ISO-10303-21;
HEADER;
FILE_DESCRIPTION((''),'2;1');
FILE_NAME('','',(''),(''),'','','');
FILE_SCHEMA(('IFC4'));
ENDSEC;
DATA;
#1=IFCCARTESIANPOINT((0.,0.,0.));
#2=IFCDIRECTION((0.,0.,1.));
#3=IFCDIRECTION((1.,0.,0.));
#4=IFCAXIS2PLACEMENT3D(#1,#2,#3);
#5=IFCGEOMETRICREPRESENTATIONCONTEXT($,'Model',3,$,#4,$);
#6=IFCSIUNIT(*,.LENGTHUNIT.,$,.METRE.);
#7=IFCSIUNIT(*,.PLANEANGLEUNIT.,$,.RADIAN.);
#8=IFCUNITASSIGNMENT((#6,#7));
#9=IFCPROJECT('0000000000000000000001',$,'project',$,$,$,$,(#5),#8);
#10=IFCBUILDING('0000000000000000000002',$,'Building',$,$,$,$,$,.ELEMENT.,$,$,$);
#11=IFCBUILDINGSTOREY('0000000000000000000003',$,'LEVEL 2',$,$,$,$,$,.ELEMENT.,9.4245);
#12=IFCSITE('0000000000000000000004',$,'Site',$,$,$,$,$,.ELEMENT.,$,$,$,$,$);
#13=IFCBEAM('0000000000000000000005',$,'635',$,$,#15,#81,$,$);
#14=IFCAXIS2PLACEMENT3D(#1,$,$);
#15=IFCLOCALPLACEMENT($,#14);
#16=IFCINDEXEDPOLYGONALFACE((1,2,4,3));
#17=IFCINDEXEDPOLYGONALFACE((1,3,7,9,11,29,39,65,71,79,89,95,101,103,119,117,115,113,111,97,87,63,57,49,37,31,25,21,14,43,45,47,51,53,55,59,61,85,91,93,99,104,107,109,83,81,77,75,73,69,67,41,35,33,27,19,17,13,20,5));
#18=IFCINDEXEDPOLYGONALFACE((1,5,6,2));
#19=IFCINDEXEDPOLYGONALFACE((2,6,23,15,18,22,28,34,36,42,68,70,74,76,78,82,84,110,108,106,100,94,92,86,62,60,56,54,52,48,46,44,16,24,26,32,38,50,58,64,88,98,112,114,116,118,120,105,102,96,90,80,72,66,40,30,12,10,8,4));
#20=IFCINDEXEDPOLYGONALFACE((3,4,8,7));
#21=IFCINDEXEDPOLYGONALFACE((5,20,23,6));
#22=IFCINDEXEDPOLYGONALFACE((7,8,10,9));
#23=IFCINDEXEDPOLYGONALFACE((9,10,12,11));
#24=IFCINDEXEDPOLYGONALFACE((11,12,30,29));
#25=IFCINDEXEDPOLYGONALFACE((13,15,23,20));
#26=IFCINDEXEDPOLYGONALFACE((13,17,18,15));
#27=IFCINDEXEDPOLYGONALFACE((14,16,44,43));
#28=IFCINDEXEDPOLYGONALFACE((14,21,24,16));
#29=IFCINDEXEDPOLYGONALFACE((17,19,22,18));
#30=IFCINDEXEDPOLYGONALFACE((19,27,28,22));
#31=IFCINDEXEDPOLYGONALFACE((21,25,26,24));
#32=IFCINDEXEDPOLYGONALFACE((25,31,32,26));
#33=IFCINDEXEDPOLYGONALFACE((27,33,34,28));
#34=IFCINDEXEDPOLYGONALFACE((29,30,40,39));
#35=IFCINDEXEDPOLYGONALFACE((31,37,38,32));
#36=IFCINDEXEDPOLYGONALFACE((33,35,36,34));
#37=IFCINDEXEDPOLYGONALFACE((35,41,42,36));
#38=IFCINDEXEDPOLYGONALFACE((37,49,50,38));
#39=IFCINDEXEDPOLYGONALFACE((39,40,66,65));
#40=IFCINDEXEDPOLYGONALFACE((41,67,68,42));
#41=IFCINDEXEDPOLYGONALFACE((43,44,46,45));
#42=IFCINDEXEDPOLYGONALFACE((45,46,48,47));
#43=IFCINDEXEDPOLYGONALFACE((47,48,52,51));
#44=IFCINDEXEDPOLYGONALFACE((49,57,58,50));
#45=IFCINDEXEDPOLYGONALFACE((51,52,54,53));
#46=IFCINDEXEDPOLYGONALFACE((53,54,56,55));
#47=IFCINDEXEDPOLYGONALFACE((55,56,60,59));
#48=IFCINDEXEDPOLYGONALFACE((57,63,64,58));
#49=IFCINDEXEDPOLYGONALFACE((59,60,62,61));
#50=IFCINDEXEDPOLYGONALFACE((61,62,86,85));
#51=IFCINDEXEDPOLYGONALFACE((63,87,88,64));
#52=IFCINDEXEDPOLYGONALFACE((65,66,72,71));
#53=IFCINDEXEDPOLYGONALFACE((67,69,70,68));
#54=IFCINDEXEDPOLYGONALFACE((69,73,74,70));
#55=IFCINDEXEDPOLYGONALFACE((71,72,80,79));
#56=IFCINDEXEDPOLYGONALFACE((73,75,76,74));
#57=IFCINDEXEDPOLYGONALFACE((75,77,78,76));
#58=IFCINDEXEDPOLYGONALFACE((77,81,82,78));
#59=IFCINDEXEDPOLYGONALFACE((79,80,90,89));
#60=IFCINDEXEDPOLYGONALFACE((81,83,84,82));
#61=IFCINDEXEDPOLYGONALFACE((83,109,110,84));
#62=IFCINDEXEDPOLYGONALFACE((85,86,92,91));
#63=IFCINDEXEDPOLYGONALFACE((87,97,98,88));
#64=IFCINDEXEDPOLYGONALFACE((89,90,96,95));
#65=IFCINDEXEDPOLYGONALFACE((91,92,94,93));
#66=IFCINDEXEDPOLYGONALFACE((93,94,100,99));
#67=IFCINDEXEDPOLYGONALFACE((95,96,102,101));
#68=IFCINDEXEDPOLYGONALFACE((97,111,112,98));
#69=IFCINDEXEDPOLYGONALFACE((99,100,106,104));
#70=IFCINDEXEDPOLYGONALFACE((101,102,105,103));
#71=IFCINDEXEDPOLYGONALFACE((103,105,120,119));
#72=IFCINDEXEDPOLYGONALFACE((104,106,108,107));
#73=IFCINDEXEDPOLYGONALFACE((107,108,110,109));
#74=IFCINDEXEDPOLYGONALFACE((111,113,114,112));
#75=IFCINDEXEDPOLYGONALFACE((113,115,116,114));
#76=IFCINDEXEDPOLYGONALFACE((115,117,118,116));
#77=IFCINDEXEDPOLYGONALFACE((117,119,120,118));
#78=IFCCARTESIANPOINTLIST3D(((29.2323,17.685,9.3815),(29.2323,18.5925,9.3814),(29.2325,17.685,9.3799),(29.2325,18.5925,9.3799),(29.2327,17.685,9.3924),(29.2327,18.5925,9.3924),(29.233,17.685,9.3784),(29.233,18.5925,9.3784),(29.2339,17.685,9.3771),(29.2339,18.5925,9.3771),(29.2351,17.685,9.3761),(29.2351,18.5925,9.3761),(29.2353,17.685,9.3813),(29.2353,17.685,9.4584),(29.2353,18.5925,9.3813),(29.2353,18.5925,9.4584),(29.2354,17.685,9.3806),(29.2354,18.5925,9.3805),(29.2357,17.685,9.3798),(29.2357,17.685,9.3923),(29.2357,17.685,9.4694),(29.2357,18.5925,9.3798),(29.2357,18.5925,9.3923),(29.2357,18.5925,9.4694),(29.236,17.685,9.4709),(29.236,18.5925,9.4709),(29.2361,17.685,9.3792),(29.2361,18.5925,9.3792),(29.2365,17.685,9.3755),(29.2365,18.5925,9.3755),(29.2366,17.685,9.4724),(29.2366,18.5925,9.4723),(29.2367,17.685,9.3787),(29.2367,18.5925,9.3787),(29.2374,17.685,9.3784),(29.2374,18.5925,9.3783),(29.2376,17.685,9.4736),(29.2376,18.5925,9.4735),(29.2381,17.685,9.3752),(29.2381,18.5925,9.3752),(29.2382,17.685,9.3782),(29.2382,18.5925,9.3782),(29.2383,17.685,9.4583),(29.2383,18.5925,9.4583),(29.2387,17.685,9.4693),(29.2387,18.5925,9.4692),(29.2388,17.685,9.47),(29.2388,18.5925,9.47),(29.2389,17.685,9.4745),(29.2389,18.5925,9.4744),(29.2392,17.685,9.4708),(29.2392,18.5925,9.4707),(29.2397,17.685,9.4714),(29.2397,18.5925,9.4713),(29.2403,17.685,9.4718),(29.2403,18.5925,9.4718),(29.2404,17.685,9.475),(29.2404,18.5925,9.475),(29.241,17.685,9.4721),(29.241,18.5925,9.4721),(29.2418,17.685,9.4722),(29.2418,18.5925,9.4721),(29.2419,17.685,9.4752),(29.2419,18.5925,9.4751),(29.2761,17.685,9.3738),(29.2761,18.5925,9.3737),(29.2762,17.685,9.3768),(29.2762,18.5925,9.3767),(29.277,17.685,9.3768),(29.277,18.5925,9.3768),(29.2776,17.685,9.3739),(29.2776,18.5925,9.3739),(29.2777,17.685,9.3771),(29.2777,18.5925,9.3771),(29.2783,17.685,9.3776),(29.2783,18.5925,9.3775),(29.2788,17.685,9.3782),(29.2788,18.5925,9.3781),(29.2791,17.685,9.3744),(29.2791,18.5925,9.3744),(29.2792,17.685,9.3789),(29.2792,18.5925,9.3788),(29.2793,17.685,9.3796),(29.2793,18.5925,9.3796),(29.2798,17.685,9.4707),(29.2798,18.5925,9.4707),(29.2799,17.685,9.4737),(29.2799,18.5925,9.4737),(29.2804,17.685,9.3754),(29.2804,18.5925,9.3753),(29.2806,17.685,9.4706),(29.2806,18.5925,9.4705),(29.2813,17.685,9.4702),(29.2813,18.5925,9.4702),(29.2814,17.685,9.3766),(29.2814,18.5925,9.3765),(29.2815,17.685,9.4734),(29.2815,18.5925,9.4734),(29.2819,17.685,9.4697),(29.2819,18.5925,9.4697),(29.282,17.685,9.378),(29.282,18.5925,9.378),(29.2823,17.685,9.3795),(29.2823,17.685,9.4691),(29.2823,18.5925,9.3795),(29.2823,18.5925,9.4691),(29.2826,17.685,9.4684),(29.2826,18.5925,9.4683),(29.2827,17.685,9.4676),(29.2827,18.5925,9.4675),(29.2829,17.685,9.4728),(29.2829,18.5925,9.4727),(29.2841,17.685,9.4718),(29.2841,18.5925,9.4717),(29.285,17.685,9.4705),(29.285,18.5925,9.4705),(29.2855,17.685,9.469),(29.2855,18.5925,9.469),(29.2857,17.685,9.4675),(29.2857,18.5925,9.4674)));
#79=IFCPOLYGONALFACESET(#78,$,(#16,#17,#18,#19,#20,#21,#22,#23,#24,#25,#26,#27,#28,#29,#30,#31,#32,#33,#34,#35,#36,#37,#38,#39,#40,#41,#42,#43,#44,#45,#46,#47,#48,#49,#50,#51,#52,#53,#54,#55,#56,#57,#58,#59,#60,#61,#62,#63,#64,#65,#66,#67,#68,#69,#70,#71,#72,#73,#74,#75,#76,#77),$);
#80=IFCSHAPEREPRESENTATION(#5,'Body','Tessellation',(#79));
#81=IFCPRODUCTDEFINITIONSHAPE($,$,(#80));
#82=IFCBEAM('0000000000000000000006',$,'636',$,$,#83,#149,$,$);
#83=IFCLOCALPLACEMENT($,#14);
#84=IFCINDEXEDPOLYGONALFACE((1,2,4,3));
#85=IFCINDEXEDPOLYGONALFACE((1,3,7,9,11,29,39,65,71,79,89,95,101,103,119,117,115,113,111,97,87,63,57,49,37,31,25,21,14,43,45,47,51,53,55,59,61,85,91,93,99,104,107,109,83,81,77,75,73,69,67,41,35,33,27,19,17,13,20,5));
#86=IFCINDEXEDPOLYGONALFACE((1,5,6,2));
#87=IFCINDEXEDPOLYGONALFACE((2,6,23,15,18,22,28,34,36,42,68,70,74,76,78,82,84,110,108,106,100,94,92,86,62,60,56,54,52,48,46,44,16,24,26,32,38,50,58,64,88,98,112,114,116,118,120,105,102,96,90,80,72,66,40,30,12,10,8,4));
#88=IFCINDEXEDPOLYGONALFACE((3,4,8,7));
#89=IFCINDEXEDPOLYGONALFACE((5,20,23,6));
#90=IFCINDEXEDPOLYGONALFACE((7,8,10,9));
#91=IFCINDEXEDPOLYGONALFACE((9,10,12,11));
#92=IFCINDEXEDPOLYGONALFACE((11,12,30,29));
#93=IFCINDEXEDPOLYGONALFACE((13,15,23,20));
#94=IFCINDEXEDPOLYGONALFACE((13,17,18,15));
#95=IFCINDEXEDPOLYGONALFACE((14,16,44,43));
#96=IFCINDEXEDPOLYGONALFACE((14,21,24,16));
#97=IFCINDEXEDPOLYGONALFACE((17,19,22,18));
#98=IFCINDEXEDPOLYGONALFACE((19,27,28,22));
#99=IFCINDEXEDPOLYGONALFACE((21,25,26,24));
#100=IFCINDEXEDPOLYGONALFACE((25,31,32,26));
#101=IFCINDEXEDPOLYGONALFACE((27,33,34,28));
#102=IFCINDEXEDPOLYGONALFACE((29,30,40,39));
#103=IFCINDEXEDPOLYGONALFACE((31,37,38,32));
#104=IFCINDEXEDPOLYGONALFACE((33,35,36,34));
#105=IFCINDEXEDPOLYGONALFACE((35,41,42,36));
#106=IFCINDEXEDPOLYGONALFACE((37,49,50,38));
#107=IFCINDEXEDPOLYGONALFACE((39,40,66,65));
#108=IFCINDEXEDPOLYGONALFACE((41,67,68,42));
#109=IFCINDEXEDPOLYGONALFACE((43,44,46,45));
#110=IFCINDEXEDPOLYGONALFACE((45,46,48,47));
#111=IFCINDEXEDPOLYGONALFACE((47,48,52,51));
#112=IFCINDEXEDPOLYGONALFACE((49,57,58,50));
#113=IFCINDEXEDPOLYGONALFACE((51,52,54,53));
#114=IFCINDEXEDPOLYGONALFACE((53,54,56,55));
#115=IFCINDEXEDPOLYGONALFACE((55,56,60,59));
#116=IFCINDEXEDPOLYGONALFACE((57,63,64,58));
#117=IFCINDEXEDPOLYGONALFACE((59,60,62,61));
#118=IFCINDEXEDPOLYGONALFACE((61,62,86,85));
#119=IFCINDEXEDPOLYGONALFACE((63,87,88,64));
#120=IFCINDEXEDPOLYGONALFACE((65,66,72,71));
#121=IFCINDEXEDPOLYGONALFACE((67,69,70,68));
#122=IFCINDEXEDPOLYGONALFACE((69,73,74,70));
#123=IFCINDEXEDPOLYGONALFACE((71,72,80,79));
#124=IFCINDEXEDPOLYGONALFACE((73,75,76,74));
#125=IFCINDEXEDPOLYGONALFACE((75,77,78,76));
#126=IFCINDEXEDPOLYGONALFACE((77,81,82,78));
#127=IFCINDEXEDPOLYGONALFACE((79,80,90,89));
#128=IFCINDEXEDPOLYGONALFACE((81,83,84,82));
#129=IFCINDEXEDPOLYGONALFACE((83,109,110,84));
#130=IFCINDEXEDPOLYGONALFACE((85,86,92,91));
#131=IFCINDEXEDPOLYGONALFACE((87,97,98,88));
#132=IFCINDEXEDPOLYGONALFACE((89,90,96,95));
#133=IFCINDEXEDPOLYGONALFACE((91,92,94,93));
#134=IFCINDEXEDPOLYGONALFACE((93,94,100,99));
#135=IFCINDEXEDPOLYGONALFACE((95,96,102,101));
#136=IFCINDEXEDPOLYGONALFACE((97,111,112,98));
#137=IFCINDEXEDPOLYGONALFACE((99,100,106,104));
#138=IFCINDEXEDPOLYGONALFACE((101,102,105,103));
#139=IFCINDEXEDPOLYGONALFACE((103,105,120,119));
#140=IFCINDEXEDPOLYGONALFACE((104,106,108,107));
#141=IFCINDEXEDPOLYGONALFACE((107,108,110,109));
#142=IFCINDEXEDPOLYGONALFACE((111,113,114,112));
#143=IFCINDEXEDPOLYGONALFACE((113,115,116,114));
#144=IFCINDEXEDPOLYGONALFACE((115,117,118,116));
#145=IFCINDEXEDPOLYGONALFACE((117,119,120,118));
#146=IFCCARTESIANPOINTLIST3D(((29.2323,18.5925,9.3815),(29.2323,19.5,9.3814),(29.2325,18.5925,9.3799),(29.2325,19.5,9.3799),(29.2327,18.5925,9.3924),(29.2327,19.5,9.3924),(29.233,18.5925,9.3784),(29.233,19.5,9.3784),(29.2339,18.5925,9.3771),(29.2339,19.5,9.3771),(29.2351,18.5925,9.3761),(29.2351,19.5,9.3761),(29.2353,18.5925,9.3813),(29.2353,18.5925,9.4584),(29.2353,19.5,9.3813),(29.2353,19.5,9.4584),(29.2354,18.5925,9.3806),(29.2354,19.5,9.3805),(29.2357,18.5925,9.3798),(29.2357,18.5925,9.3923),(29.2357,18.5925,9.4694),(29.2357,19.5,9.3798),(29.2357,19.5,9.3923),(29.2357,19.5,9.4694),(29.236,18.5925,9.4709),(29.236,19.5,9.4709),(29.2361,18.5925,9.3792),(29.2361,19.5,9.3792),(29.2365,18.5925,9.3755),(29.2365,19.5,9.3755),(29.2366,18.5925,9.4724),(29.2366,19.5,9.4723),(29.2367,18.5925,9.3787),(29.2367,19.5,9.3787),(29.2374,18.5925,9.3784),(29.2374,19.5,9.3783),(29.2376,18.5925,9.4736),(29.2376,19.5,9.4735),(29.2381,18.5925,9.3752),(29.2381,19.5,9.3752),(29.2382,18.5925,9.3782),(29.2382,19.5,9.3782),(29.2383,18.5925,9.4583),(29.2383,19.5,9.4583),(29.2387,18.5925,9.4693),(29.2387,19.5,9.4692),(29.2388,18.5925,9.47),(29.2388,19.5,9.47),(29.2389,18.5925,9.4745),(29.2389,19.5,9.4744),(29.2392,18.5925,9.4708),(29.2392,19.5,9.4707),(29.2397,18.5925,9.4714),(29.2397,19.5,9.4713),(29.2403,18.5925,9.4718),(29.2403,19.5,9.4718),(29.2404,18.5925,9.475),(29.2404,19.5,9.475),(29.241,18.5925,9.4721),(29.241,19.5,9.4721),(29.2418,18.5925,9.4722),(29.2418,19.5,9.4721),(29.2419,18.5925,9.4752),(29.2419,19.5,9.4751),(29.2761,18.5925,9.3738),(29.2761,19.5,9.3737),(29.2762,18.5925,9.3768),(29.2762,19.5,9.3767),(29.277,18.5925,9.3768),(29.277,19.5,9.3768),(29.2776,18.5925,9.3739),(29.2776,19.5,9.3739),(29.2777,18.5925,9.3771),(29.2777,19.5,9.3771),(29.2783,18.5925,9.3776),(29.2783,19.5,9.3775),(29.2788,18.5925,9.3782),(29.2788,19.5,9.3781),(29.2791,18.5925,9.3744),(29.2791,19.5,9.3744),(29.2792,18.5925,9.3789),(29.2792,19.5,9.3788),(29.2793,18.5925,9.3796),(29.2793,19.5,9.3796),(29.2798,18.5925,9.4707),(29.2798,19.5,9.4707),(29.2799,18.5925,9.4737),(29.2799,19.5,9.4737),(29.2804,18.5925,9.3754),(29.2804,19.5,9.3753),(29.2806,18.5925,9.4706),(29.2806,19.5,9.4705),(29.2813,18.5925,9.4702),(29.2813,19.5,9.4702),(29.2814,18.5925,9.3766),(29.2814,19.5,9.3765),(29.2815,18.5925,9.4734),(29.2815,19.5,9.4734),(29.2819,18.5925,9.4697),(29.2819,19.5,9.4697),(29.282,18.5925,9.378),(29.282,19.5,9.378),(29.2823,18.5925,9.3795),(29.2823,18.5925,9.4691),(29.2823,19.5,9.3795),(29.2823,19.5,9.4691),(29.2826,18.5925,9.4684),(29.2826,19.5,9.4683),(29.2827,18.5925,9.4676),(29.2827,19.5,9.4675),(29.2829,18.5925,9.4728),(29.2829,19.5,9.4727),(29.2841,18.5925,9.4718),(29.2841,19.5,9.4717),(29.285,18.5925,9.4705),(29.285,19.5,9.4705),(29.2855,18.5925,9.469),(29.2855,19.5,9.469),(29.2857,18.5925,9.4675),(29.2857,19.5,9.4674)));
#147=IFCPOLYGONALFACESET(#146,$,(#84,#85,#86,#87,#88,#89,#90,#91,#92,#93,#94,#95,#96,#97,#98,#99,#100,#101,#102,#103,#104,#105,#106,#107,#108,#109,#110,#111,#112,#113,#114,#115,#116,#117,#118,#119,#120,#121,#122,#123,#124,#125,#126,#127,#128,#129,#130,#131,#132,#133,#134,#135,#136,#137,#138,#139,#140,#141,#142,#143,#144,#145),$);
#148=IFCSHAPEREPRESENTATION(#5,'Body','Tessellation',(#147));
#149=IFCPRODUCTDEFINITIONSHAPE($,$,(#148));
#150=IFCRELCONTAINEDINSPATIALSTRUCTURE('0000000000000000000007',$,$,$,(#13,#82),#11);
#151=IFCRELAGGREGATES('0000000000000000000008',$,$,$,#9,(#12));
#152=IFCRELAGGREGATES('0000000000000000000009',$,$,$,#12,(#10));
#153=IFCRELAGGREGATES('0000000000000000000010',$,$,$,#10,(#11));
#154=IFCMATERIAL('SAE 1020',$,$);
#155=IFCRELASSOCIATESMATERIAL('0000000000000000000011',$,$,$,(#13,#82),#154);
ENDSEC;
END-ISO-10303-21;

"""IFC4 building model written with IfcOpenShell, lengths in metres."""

from ifc_helpers import new_model, si_unit, frame, origin_with_axes, origin_2d_with_axis, place, context, project, spatial, c_section, extrude, material, material_profile, profile_set, profile_usage, element, save


model = new_model("IFC4")

# Units and contexts
model_context = context("Model", 3, world=origin_with_axes())
ifc_project = project(units=[si_unit("LENGTHUNIT", "METRE"), si_unit("PLANEANGLEUNIT", "RADIAN")], contexts=[model_context])

# Site, building, storey
site = spatial("IfcSite", under=ifc_project, Name="Site", CompositionType="ELEMENT")
building = spatial("IfcBuilding", under=site, Name="Building", CompositionType="ELEMENT")
storey = spatial("IfcBuildingStorey", under=building, Name="LEVEL 2", CompositionType="ELEMENT", Elevation=9.4245)

# Beams
ifc_material = material(Name="SAE 1020")
ifc_material_profile_1 = material_profile(ifc_material, c_section(Depth=0.1, Width=0.05, WallThickness=0.003, Girth=0.017, InternalFilletRadius=0.003, at=origin_2d_with_axis()))
ifc_profile_set_1 = profile_set([ifc_material_profile_1])
ifc_profile_usage_1 = profile_usage(ifc_profile_set_1, cardinal=10)
beam_1_placement = place(None, frame((29.259, 17.685, 9.4245), z_axis=(0.0, 1.0, -0.00003), x_axis=(-0.999256, 0.000001, 0.038562)))
element("IfcBeam", 1, at=beam_1_placement, inside=storey, material=ifc_profile_usage_1, Name="635", context=model_context, shape_type="SweptSolid", body=[
    extrude(c_section(Depth=0.1, Width=0.05, WallThickness=0.003, Girth=0.017, InternalFilletRadius=0.003, at=origin_2d_with_axis()), origin_with_axes(), (0.0, 0.0, 1.0), 0.9075),
])
ifc_material_profile_2 = material_profile(ifc_material, c_section(Depth=0.1, Width=0.05, WallThickness=0.003, Girth=0.017, InternalFilletRadius=0.003, at=origin_2d_with_axis()))
ifc_profile_set_2 = profile_set([ifc_material_profile_2])
ifc_profile_usage_2 = profile_usage(ifc_profile_set_2, cardinal=10)
beam_2_placement = place(None, frame((29.259, 18.5925, 9.4245), z_axis=(0.0, 1.0, -0.00003), x_axis=(-0.999256, 0.000001, 0.038562)))
element("IfcBeam", 2, at=beam_2_placement, inside=storey, material=ifc_profile_usage_2, Name="636", context=model_context, shape_type="SweptSolid", body=[
    extrude(c_section(Depth=0.1, Width=0.05, WallThickness=0.003, Girth=0.017, InternalFilletRadius=0.003, at=origin_2d_with_axis()), origin_with_axes(), (0.0, 0.0, 1.0), 0.9075),
])

save(model, "model.ifc")
